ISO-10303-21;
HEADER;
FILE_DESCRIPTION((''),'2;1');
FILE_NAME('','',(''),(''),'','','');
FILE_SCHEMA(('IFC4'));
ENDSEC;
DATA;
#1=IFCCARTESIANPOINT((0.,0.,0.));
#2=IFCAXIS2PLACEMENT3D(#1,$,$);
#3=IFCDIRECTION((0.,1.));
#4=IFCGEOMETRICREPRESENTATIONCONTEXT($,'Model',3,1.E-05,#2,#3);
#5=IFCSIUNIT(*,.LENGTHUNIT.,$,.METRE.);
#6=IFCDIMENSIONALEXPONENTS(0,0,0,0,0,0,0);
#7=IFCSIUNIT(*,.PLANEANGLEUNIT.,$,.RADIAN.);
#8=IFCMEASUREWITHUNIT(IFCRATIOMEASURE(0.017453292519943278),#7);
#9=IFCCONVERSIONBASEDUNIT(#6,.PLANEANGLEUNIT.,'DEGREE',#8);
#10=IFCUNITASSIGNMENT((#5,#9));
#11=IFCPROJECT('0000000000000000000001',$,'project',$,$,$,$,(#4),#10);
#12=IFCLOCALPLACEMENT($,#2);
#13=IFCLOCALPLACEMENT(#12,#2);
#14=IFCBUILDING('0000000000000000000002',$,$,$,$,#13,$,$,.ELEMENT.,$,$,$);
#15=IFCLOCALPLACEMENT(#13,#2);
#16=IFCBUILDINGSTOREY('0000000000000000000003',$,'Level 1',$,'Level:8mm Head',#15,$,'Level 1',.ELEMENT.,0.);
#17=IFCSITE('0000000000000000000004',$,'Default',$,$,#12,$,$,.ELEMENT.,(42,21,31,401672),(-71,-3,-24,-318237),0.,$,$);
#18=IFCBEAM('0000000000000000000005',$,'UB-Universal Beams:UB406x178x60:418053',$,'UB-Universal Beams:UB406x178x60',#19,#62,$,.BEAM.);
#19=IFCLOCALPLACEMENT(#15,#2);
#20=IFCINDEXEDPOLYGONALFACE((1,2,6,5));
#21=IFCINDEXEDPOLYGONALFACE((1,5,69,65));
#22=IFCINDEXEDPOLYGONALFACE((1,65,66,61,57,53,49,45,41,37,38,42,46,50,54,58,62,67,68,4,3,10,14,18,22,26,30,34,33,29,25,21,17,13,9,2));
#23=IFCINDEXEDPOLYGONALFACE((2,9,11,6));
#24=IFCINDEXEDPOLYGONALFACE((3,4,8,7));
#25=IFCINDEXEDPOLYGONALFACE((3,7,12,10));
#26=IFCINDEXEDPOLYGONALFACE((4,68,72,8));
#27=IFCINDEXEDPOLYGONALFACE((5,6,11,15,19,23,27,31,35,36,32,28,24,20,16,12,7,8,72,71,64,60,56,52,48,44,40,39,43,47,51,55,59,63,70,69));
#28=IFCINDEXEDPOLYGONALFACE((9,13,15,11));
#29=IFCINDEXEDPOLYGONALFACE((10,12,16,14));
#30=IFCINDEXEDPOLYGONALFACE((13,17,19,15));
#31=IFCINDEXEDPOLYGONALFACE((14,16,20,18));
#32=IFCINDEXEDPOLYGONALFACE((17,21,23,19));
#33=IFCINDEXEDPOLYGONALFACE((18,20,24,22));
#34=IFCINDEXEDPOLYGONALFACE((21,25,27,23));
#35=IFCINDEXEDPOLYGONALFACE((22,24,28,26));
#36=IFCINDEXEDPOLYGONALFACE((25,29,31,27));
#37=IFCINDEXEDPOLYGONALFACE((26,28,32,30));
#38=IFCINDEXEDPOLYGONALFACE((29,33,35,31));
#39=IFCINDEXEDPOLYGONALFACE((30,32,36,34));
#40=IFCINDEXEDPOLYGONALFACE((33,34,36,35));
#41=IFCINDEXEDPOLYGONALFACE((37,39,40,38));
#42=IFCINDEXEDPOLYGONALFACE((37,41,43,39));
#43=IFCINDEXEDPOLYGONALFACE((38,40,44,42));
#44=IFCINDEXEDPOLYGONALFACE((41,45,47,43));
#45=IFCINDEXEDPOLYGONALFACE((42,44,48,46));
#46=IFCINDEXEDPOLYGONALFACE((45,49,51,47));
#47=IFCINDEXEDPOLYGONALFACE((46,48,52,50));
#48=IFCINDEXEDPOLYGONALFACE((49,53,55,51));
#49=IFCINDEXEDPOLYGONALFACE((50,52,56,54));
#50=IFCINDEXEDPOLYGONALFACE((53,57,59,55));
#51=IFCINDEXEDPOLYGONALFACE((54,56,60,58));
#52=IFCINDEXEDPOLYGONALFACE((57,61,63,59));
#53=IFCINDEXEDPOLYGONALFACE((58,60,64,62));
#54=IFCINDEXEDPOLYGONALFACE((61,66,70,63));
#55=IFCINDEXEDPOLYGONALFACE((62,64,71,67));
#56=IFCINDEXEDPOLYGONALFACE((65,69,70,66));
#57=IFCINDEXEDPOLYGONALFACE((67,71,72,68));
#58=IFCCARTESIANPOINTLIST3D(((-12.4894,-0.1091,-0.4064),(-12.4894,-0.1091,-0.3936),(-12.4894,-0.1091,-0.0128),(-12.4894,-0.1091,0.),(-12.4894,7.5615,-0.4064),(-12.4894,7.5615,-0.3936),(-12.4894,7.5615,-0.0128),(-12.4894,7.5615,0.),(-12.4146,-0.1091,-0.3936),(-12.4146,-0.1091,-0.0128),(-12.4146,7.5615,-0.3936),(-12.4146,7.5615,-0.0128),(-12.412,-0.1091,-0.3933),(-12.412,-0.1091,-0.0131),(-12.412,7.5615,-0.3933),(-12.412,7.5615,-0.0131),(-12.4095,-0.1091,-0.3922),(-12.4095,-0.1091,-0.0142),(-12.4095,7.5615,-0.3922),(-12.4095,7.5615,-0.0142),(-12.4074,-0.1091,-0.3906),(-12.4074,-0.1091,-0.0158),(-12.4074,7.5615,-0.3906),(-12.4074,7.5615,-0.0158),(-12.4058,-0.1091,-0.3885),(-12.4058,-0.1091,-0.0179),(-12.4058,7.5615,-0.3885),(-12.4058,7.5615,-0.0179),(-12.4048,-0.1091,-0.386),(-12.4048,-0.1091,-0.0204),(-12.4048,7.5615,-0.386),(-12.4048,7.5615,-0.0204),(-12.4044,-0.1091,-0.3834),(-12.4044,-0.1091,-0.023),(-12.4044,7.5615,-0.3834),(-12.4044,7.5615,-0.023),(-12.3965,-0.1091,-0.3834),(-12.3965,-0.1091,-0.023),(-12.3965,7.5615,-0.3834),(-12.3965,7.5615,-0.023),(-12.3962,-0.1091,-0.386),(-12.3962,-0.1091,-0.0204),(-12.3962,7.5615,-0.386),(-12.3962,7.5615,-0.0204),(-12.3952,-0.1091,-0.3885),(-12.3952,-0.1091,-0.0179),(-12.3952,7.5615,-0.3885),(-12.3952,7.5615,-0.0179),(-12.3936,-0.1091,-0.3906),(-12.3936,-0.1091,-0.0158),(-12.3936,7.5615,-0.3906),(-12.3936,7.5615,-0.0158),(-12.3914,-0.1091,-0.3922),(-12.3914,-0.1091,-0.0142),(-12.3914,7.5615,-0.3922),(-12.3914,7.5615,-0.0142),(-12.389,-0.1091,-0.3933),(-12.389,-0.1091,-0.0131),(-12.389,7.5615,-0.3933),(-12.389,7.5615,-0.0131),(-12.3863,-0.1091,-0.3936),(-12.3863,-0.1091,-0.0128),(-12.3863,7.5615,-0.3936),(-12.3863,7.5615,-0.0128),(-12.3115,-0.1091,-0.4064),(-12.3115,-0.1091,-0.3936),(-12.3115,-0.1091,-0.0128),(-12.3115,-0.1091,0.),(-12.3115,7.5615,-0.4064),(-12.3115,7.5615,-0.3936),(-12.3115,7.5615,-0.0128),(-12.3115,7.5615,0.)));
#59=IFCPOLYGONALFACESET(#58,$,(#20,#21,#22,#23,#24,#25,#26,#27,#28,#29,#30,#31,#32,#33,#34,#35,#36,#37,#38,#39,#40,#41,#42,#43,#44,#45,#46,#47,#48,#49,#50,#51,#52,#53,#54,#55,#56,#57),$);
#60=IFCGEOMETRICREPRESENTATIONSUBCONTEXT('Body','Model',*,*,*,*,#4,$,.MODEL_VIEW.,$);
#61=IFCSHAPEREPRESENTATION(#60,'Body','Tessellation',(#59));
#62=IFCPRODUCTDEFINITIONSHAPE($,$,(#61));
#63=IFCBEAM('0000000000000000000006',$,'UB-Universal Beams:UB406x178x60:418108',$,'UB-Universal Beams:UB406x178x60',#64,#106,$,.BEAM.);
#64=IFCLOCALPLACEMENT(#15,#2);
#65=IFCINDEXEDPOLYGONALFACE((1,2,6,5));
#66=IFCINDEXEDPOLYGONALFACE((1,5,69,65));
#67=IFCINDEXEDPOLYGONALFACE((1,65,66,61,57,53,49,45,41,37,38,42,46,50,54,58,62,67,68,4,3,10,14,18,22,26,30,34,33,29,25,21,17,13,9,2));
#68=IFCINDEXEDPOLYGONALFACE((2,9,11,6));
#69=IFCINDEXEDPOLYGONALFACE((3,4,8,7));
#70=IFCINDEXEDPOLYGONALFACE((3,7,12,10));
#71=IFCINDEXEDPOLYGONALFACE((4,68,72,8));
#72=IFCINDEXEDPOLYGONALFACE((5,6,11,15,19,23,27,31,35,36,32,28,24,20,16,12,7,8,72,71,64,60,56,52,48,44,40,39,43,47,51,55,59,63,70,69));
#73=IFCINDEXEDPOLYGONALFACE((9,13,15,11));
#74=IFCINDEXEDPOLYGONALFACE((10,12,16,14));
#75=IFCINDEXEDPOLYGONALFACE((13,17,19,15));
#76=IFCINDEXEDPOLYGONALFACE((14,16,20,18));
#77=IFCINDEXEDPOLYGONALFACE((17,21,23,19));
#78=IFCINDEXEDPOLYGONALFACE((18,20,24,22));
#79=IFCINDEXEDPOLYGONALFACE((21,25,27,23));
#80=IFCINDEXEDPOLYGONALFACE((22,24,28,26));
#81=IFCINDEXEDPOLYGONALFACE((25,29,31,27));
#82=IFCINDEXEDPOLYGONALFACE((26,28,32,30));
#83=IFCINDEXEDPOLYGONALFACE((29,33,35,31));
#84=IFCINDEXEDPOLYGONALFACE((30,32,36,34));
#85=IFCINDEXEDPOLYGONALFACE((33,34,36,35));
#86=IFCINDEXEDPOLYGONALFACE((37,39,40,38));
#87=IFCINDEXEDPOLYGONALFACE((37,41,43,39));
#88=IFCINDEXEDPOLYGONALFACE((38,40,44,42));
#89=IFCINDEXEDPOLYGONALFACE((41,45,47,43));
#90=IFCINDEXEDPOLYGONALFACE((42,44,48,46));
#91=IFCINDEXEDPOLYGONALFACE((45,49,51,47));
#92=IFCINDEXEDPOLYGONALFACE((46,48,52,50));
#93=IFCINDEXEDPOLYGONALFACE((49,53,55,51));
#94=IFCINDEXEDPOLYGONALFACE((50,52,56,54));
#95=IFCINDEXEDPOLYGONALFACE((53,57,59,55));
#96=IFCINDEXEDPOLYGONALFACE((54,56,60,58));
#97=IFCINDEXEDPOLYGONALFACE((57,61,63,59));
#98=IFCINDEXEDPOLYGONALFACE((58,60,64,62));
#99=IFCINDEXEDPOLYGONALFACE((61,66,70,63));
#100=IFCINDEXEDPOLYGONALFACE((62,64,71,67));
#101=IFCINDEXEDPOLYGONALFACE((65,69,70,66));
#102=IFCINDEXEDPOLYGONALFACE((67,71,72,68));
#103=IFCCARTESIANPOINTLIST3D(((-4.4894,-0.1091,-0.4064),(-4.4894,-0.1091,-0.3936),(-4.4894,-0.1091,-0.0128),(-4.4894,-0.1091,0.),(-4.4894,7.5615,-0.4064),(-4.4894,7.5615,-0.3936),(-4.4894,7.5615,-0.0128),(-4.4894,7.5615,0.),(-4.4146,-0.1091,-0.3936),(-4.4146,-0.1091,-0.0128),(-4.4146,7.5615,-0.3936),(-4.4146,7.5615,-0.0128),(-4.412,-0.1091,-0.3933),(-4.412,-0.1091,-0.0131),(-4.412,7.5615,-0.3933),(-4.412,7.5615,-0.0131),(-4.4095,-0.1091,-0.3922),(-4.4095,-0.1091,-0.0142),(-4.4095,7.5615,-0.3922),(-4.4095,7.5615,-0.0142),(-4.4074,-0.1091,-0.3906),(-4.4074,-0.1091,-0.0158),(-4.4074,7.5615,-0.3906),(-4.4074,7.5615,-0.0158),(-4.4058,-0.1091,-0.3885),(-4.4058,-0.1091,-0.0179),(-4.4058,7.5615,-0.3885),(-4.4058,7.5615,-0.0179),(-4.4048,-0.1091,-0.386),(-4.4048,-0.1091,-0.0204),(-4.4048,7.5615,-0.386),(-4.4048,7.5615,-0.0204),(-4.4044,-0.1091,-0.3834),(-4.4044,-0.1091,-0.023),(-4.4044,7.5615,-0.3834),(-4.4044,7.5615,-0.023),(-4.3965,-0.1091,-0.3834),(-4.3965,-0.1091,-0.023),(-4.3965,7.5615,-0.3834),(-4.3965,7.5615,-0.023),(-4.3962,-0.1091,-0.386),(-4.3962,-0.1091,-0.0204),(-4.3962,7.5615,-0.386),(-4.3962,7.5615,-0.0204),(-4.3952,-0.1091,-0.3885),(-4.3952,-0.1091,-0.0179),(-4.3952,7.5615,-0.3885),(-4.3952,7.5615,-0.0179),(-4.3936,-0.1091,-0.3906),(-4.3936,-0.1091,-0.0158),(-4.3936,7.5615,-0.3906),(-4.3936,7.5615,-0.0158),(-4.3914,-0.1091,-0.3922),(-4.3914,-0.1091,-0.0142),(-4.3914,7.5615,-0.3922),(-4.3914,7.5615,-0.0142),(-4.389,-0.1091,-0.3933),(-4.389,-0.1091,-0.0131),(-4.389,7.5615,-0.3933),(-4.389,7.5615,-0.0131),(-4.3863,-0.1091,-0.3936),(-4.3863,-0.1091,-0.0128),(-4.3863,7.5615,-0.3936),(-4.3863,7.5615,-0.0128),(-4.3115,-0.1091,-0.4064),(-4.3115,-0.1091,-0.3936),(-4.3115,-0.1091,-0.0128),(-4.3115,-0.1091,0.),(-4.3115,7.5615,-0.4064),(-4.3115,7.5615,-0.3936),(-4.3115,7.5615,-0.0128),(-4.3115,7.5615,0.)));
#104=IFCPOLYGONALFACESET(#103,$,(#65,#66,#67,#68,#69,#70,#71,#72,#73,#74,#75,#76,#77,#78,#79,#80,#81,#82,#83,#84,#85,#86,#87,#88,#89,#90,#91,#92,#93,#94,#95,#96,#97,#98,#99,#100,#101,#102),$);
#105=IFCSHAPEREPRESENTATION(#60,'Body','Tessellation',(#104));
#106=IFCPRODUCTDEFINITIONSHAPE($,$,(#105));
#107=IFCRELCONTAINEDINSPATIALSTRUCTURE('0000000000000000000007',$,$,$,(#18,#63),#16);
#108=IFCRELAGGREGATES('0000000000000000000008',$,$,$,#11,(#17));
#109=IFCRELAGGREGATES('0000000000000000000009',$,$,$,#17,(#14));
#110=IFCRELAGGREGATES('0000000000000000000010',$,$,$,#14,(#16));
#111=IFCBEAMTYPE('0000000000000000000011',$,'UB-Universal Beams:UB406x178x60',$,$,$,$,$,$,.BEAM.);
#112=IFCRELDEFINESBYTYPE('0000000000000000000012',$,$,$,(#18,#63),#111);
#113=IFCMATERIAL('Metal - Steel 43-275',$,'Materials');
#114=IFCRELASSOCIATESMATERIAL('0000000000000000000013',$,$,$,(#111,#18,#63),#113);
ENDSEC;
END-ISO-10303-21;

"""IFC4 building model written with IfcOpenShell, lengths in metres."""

from ifc_helpers import new_model, entity, si_unit, converted_unit, direction, frame, origin, place, context, subcontext, project, spatial, line, arc, indexed_curve, outline, extrude, source, transform, mapped, material, type_object, type_shapes, element, save


model = new_model("IFC4")

# Units and contexts
model_context = context("Model", 3, precision=1e-05, world=origin(), true_north=direction((0.0, 1.0)))
body_context = subcontext(model_context, "Body", "Model", "MODEL_VIEW")
ifc_project = project(units=[si_unit("LENGTHUNIT", "METRE"), converted_unit("PLANEANGLEUNIT", "DEGREE", entity("IfcRatioMeasure", 0.017453292519943278), si_unit("PLANEANGLEUNIT", "RADIAN"), dimensions=[0, 0, 0, 0, 0, 0, 0])], contexts=[model_context])

# Site, building, storey
site_placement = place(None, origin())
site = spatial("IfcSite", under=ifc_project, at=site_placement, Name="Default", CompositionType="ELEMENT", RefLatitude=(42, 21, 31, 401672), RefLongitude=(-71, -3, -24, -318237), RefElevation=0.0)
building_placement = place(site_placement, origin())
building = spatial("IfcBuilding", under=site, at=building_placement, CompositionType="ELEMENT")
storey_placement = place(building_placement, origin())
storey = spatial("IfcBuildingStorey", under=building, at=storey_placement, Name="Level 1", ObjectType="Level:8mm Head", LongName="Level 1", CompositionType="ELEMENT", Elevation=0.0)

# Beams
ifc_material_1 = material(Name="Metal - Steel 43-275", Category="Materials")
beam_type_1 = type_object("IfcBeamType", Name="UB-Universal Beams:UB406x178x60", PredefinedType="BEAM", material=ifc_material_1)
shared_shape_1 = source(origin(), body_context, "Body", "SweptSolid", [
    extrude(outline(indexed_curve([(-0.2032, -0.089), (-0.1904, -0.089), (-0.1904, -0.0141), (-0.1874, -0.0069), (-0.1802, -0.0039), (0.1802, -0.0039), (0.1874, -0.0069), (0.1904, -0.0141), (0.1904, -0.089), (0.2032, -0.089), (0.2032, 0.089), (0.1904, 0.089), (0.1904, 0.0142), (0.1874, 0.0069), (0.1802, 0.004), (-0.1802, 0.004), (-0.1874, 0.0069), (-0.1904, 0.0142), (-0.1904, 0.0889), (-0.2032, 0.0889)], segments=[line(1, 2, 3), arc(3, 4, 5), line(5, 6), arc(6, 7, 8), line(8, 9, 10, 11, 12, 13), arc(13, 14, 15), line(15, 16), arc(16, 17, 18), line(18, 19, 20, 1)], self_intersect=False)), frame((-3.8373, 0.0, 0.0), z_axis=(1.0, 0.0, 0.0), x_axis=(0.0, 0.0, -1.0)), (0.0, 0.0, 1.0), 7.6706),
])
type_shapes(beam_type_1, [shared_shape_1])
for number, where, z_axis, x_axis, name in (
    (1, (-12.4005, 3.7282, -0.2032), (0.0, 0.0, 1.0), (0.0, 1.0, 0.0), "UB-Universal Beams:UB406x178x60:418053"),
    (2, (-4.4005, 3.7282, -0.2032), (0.0, 0.0, 1.0), (0.0, 1.0, 0.0), "UB-Universal Beams:UB406x178x60:418108"),
):
    element("IfcBeam", number, at=place(storey_placement, frame(where, z_axis=z_axis, x_axis=x_axis)), inside=storey, type_object=beam_type_1, material=ifc_material_1, Name=name, ObjectType="UB-Universal Beams:UB406x178x60", PredefinedType="BEAM", context=body_context, shape_type="MappedRepresentation", body=[
        mapped(shared_shape_1, transform((0.0, 0.0, 0.0), scale=1.0)),
    ])

save(model, "model.ifc")
